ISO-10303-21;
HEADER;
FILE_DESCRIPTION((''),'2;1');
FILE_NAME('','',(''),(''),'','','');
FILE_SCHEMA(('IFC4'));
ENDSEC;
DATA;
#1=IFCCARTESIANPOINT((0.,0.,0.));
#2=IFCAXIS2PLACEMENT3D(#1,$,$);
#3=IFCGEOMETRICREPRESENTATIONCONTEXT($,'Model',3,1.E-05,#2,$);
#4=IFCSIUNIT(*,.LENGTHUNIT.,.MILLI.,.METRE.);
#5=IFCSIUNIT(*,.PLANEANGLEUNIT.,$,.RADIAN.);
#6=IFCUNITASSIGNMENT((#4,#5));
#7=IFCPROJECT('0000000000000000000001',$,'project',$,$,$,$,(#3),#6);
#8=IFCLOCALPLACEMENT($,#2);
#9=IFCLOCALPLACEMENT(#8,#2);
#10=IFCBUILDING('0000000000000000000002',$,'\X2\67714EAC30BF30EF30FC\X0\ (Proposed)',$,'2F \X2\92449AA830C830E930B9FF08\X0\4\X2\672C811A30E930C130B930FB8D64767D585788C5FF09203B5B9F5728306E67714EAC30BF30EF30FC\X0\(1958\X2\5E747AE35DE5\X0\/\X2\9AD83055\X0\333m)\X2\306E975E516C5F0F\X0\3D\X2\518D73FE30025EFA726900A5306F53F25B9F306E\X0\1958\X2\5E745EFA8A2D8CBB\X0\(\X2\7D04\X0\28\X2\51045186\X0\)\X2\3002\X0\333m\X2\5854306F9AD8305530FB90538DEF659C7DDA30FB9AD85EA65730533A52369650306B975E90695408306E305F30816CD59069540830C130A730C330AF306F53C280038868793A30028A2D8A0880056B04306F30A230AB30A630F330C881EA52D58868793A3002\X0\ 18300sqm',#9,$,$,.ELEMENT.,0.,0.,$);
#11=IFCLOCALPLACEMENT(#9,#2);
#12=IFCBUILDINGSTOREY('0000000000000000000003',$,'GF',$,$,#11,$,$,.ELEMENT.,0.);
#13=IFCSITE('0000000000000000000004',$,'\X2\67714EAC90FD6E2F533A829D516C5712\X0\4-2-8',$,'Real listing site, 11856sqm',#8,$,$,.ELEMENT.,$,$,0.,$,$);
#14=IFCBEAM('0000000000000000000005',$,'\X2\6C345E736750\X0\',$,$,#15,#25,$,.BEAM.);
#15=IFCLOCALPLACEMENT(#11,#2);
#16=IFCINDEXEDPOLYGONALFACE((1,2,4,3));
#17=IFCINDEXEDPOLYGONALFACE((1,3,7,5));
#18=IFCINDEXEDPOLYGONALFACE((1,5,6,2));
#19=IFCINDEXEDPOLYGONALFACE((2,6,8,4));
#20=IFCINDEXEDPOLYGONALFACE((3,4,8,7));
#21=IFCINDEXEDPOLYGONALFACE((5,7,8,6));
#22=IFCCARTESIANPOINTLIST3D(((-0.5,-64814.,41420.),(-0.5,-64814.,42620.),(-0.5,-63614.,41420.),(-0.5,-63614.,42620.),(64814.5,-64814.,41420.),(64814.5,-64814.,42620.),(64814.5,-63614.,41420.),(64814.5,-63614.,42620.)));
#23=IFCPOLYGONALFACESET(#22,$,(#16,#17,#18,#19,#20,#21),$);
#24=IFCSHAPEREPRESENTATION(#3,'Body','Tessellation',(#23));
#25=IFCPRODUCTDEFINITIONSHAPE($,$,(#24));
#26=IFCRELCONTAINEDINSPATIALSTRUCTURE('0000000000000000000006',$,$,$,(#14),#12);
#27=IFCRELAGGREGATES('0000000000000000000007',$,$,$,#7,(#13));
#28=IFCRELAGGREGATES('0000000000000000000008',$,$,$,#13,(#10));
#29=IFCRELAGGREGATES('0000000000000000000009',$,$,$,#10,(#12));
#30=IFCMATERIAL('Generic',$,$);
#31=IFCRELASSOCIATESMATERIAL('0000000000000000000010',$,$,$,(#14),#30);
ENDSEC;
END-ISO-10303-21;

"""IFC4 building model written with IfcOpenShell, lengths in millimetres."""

from ifc_helpers import new_model, si_unit, frame, frame_2d, origin, place, context, project, spatial, rectangle, extrude, material, element, save


model = new_model("IFC4")

# Units and contexts
model_context = context("Model", 3, precision=1e-05, world=origin())
ifc_project = project(units=[si_unit("LENGTHUNIT", "METRE", prefix="MILLI"), si_unit("PLANEANGLEUNIT", "RADIAN")], contexts=[model_context])

# Site, building, storey
site_placement = place(None, origin())
site = spatial("IfcSite", under=ifc_project, at=site_placement, Name="東京都港区芝公園4-2-8", ObjectType="Real listing site, 11856sqm", CompositionType="ELEMENT", RefElevation=0.0)
building_placement = place(site_placement, origin())
building = spatial("IfcBuilding", under=site, at=building_placement, Name="東京タワー (Proposed)", ObjectType="2F 鉄骨トラス（4本脚ラチス・赤白塗装）※実在の東京タワー(1958年竣工/高さ333m)の非公式3D再現。建物¥は史実の1958年建設費(約28億円)。333m塔は高さ・道路斜線・高度地区制限に非適合のため法適合チェックは参考表示。設計者欄はアカウント自動表示。 18300sqm", CompositionType="ELEMENT", ElevationOfRefHeight=0.0, ElevationOfTerrain=0.0)
storey_placement = place(building_placement, origin())
storey = spatial("IfcBuildingStorey", under=building, at=storey_placement, Name="GF", CompositionType="ELEMENT", Elevation=0.0)

# Shared definitions
ifc_material = material(Name="Generic")

# Beam
beam_placement = place(storey_placement, frame((0.0, -32407.0, 20710.0)))
element("IfcBeam", 1, at=beam_placement, inside=storey, material=ifc_material, Name="水平材", PredefinedType="BEAM", context=model_context, shape_type="SweptSolid", body=[
    extrude(rectangle(XDim=64815.0, YDim=1200.0, at=frame_2d((32407.0, 600.0))), frame((0.0, -32407.0, 20710.0)), (0.0, 0.0, 1.0), 1200.0),
])

save(model, "model.ifc")
